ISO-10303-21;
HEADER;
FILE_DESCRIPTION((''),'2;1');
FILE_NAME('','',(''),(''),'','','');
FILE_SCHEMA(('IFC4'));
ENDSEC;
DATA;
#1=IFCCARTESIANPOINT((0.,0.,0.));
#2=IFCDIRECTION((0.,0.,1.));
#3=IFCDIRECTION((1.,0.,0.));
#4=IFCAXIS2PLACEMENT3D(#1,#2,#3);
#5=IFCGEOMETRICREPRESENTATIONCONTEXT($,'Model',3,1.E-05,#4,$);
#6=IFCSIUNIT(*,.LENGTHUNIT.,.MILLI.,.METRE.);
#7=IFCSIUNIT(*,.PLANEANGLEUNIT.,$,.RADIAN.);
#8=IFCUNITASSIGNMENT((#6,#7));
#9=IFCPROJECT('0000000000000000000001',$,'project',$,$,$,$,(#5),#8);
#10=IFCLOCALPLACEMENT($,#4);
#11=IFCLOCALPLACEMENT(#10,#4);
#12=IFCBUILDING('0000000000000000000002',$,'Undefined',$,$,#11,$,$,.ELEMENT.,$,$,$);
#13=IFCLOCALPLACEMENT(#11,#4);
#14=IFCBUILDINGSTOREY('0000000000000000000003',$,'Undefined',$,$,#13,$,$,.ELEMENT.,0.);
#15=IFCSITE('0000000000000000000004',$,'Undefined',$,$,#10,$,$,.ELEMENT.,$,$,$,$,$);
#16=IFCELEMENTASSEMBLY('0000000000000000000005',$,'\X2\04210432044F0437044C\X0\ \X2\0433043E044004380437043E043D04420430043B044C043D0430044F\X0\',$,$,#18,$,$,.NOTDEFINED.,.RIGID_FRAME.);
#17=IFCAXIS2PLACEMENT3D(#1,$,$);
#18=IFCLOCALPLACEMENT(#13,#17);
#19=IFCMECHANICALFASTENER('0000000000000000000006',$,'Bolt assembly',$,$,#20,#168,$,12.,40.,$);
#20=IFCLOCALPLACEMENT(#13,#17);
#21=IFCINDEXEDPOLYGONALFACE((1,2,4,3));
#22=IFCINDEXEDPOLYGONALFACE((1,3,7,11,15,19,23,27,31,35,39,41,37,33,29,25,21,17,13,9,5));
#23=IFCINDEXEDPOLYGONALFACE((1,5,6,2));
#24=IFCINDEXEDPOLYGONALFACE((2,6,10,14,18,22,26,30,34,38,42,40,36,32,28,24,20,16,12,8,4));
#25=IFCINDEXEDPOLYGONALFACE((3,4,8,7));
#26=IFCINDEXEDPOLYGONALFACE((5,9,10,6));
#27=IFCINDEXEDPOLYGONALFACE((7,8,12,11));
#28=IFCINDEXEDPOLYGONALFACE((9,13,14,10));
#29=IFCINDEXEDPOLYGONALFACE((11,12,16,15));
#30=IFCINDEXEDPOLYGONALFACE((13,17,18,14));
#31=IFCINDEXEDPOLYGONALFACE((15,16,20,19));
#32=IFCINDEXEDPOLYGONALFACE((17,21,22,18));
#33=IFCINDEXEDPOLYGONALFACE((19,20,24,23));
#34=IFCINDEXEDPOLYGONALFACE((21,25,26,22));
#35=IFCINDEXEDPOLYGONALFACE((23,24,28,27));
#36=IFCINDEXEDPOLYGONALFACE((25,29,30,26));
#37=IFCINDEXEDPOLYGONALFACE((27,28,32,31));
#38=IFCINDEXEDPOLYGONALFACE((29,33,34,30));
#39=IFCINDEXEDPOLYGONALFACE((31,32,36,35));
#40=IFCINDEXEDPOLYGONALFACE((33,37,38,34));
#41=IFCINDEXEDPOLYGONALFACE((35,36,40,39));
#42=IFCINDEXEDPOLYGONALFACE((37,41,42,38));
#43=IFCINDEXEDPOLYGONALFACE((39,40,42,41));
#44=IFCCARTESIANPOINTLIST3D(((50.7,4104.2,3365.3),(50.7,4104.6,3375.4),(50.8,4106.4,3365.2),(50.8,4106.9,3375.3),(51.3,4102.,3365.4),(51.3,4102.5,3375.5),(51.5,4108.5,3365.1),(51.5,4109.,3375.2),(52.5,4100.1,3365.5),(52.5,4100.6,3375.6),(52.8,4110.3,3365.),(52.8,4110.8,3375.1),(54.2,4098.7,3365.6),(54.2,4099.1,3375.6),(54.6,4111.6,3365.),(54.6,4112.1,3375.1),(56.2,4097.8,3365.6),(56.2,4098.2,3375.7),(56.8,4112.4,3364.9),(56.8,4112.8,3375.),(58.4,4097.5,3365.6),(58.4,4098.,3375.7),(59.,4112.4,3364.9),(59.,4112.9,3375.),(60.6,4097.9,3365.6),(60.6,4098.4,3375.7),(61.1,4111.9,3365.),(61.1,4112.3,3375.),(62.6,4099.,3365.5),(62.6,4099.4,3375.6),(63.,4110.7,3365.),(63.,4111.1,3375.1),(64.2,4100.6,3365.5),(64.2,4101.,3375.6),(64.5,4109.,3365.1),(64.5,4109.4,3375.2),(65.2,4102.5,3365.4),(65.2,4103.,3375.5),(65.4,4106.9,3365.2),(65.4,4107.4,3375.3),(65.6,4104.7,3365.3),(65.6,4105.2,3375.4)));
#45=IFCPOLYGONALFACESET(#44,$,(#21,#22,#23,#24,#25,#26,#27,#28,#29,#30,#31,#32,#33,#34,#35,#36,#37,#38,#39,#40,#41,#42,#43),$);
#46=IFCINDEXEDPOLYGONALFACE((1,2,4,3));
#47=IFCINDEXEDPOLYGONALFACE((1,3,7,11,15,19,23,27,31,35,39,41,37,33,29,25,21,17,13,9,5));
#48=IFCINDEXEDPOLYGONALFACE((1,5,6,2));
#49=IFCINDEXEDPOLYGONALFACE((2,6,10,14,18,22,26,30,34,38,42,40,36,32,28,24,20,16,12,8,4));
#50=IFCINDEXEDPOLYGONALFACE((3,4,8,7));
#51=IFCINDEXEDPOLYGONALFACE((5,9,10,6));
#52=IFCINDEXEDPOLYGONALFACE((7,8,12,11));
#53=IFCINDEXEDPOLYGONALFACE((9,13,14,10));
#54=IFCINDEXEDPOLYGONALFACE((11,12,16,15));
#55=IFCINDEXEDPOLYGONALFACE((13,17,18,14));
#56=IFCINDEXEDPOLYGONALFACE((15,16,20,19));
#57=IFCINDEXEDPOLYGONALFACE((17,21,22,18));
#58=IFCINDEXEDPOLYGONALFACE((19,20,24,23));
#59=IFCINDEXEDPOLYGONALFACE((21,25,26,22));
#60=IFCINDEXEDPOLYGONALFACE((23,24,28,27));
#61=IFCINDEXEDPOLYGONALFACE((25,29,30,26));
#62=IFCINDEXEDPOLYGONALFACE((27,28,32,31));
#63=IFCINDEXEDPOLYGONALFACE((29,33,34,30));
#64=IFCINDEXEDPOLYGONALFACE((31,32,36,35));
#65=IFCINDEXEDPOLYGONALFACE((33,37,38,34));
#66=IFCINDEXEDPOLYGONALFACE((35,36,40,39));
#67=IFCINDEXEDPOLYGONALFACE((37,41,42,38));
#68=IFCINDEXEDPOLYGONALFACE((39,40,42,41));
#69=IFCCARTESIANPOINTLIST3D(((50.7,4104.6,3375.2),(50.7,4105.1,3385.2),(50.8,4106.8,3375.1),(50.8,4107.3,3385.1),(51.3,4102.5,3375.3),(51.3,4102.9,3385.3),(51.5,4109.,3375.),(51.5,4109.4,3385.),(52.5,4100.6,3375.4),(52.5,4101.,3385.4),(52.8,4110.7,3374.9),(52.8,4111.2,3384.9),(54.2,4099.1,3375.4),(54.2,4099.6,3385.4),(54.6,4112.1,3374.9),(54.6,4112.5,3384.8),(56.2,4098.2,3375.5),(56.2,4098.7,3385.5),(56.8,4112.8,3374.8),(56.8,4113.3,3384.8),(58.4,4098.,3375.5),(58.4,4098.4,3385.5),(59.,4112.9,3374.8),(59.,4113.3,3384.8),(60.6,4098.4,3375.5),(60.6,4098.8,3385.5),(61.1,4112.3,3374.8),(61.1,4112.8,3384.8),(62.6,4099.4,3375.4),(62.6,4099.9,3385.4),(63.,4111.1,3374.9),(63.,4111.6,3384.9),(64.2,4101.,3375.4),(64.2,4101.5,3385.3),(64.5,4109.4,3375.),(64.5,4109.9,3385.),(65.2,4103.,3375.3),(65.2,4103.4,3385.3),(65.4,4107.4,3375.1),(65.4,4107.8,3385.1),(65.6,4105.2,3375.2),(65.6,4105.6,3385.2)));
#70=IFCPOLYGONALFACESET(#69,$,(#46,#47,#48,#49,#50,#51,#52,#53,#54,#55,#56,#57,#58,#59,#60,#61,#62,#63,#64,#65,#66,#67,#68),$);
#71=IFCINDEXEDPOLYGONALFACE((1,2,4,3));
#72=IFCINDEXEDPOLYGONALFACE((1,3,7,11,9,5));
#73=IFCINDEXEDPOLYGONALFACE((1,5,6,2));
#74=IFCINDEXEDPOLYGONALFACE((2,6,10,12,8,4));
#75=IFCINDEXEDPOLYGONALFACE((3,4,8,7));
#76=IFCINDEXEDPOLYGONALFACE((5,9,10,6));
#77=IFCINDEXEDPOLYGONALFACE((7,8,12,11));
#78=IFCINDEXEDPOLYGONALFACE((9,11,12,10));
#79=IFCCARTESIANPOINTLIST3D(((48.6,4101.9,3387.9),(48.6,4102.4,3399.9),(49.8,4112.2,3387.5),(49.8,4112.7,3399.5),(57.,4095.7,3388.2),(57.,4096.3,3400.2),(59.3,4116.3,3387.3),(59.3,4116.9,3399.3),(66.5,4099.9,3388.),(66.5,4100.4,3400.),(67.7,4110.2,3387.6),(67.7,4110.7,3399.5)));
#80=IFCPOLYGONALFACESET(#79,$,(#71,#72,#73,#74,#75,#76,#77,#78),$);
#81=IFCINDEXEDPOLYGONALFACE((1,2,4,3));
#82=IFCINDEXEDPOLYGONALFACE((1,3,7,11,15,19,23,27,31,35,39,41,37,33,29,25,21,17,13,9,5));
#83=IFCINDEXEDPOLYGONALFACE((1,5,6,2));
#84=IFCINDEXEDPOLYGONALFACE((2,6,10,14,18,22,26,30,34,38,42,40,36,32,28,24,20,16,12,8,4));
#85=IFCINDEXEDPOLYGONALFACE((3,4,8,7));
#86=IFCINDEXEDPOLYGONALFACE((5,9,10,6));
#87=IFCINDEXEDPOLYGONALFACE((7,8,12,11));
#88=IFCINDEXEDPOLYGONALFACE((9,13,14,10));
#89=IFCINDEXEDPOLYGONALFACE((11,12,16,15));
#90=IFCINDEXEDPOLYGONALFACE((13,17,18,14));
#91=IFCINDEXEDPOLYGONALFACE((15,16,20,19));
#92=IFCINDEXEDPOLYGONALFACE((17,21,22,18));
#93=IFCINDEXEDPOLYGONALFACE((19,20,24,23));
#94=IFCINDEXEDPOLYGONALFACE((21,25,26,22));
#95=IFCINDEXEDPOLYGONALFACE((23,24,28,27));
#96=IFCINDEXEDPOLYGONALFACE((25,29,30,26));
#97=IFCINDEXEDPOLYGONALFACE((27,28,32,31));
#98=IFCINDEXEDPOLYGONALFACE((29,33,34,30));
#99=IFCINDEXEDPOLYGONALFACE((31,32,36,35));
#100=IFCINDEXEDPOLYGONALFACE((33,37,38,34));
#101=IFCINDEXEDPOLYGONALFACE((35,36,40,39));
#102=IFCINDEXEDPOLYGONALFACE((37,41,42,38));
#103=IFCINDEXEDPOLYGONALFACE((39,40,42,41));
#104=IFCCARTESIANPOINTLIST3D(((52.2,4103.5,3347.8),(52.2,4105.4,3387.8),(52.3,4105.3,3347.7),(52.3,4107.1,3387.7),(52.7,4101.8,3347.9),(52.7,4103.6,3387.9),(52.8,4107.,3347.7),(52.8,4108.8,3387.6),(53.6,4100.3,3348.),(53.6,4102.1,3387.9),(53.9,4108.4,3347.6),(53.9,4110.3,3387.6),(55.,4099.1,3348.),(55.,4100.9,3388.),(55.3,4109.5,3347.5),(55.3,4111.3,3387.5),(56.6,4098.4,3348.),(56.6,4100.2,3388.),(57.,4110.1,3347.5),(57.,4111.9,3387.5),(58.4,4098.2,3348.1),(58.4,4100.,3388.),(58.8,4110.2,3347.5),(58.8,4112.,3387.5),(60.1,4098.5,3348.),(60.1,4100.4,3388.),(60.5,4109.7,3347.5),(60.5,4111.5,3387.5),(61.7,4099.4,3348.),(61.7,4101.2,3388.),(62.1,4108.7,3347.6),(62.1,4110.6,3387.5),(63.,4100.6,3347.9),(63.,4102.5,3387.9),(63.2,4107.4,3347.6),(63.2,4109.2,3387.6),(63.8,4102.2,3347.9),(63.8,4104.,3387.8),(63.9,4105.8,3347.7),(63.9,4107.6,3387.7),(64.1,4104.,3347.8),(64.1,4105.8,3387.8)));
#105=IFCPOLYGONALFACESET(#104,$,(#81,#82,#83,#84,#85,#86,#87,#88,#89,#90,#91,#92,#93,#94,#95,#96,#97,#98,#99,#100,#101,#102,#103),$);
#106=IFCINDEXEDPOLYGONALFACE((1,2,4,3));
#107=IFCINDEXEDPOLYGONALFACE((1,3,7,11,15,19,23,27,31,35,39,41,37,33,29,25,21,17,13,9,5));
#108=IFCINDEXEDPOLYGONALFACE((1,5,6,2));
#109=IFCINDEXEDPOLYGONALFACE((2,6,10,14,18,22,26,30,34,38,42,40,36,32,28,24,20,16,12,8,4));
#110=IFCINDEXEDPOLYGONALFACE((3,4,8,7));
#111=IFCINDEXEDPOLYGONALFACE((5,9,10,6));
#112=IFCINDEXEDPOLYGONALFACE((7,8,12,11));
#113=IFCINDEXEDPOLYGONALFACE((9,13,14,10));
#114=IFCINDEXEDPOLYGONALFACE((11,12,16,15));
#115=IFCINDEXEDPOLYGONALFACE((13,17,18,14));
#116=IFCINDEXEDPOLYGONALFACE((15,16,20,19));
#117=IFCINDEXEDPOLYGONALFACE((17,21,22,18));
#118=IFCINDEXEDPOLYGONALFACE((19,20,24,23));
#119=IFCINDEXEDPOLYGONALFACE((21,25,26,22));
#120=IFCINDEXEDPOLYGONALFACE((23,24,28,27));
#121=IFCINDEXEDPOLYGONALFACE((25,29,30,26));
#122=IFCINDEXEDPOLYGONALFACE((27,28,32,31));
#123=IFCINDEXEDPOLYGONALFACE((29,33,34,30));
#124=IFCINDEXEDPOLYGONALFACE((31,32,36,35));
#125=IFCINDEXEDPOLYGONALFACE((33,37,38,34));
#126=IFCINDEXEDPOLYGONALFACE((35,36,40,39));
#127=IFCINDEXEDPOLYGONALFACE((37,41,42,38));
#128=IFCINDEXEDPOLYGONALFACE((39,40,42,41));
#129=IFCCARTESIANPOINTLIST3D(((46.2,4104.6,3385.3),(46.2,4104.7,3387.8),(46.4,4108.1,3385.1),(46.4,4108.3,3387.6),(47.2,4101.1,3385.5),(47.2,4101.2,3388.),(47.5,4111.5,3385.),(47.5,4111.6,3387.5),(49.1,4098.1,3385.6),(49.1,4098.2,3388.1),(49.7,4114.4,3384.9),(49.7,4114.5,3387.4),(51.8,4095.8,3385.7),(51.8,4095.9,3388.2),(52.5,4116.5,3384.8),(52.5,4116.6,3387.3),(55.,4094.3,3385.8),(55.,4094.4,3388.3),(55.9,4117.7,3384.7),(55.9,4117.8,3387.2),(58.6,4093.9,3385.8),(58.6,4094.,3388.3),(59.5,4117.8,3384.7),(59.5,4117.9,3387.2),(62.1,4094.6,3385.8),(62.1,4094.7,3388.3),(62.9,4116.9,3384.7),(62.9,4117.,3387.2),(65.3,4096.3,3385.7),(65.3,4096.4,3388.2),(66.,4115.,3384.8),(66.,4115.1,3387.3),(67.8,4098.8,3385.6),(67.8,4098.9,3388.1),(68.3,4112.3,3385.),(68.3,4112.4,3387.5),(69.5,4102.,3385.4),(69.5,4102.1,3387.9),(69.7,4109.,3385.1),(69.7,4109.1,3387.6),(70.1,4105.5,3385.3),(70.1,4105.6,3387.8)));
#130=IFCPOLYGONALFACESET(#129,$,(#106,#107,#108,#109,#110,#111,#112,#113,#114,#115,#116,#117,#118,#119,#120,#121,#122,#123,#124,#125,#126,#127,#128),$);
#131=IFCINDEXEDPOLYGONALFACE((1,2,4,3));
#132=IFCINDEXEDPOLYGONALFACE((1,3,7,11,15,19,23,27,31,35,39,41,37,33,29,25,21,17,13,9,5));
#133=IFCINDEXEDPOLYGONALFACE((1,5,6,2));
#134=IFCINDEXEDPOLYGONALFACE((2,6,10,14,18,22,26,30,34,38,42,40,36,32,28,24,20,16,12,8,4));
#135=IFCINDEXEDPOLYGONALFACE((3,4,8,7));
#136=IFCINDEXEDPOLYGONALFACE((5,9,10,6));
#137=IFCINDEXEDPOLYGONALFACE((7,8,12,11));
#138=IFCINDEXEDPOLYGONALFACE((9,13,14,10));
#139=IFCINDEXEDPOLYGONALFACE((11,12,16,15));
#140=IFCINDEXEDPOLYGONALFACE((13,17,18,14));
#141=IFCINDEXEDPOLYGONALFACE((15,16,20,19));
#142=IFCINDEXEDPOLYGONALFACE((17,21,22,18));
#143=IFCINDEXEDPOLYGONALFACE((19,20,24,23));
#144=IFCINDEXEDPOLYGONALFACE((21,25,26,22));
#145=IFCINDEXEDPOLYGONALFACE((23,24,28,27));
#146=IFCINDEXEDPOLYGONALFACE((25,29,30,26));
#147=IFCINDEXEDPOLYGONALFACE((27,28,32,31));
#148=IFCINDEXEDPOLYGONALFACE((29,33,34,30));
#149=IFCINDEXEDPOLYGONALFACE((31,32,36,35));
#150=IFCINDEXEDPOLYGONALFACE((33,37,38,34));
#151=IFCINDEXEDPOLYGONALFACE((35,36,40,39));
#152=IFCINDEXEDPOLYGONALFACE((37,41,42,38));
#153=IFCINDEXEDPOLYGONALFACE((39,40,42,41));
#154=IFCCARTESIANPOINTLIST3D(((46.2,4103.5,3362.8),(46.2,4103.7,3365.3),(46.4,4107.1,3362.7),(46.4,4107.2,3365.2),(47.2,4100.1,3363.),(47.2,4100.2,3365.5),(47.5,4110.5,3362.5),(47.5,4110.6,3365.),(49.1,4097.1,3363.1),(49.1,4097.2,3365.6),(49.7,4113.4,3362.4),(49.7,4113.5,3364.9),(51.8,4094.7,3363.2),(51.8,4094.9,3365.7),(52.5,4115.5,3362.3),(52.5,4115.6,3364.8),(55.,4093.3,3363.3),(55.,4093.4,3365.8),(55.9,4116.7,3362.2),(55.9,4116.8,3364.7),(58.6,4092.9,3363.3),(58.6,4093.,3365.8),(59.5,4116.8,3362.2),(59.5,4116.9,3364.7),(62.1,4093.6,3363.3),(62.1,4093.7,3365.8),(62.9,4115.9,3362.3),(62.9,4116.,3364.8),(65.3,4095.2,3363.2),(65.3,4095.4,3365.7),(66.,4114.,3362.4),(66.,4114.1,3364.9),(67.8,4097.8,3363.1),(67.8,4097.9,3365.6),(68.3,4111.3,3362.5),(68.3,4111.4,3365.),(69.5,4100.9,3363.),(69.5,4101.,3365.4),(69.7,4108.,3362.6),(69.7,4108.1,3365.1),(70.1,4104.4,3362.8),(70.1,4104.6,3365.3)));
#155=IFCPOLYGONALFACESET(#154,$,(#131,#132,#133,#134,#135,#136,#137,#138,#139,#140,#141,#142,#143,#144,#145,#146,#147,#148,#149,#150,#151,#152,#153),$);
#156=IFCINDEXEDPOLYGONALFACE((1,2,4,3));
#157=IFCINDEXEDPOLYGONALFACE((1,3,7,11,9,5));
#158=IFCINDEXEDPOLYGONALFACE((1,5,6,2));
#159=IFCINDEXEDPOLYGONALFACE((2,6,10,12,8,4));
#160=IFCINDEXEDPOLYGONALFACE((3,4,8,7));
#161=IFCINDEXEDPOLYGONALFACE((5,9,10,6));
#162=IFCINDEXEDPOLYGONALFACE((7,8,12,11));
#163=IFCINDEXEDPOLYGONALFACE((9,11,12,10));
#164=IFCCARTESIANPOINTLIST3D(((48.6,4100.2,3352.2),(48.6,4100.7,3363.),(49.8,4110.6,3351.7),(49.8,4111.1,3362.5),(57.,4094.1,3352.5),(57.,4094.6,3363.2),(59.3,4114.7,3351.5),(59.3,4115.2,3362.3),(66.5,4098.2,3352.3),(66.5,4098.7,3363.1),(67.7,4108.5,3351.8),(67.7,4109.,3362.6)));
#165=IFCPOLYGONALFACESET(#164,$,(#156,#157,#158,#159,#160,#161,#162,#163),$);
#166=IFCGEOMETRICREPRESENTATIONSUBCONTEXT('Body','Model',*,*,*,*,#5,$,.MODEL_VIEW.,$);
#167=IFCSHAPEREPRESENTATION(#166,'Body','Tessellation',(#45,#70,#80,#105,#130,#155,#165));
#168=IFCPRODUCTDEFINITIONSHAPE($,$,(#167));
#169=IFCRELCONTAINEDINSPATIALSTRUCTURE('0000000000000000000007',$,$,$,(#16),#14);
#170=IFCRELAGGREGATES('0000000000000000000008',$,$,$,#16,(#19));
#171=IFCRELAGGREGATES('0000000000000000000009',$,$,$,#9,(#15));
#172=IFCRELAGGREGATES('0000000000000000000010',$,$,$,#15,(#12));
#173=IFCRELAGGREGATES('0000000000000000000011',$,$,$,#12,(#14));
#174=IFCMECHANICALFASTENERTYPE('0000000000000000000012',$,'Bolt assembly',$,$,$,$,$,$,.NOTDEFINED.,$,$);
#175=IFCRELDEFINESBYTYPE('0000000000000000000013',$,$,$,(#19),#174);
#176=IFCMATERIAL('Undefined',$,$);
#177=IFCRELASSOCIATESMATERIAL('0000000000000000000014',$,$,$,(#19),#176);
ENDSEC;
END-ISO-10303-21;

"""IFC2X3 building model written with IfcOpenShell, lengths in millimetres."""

from ifc_helpers import new_model, si_unit, frame, origin_with_axes, origin_2d_with_axis, place, context, subcontext, project, spatial, polyline, circle, outline, extrude, source, transform, mapped, material, type_object, element, aggregate, save


model = new_model("IFC2X3")

# Units and contexts
model_context = context("Model", 3, precision=1e-05, world=origin_with_axes())
body_context = subcontext(model_context, "Body", "Model", "MODEL_VIEW")
ifc_project = project(units=[si_unit("LENGTHUNIT", "METRE", prefix="MILLI"), si_unit("PLANEANGLEUNIT", "RADIAN")], contexts=[model_context])

# Site, building, storey
site_placement = place(None, origin_with_axes())
site = spatial("IfcSite", under=ifc_project, at=site_placement, Name="Undefined", CompositionType="ELEMENT")
building_placement = place(site_placement, origin_with_axes())
building = spatial("IfcBuilding", under=site, at=building_placement, Name="Undefined", CompositionType="ELEMENT")
storey_placement = place(building_placement, origin_with_axes())
storey = spatial("IfcBuildingStorey", under=building, at=storey_placement, Name="Undefined", CompositionType="ELEMENT", Elevation=0.0)

# Element assembly
assembly_1_placement = place(storey_placement, origin_with_axes())
assembly_1 = element("IfcElementAssembly", 1, at=assembly_1_placement, inside=storey, Name="Связь горизонтальная", AssemblyPlace="NOTDEFINED", PredefinedType="RIGID_FRAME")

# Mechanical fastener
ifc_material_1 = material(Name="Undefined")
mechanical_fastener_type = type_object("IfcMechanicalFastenerType", Name="Bolt assembly")
shared_shape_1 = source(origin_with_axes(), body_context, "Body", "SweptSolid", [
    extrude(circle(Radius=7.5, at=origin_2d_with_axis()), frame((0.0, -0.1, 0.0), z_axis=(0.0, 1.0, 0.0), x_axis=(1.0, 0.0, 0.0)), (0.0, 0.0, 1.0), 10.1),
    extrude(circle(Radius=7.5, at=origin_2d_with_axis()), frame((0.0, -9.9, 0.0), z_axis=(0.0, 1.0, 0.0), x_axis=(1.0, 0.0, 0.0)), (0.0, 0.0, 1.0), 10.0),
    extrude(outline(polyline([(10.4, 0.0), (5.2, 9.0), (-5.2, 9.0), (-10.4, 0.0), (-5.2, -9.0), (5.2, -9.0), (10.4, 0.0)])), frame((0.0, -24.5, 0.0), z_axis=(0.0, 1.0, 0.0), x_axis=(1.0, 0.0, 0.0)), (0.0, 0.0, 1.0), 12.0),
    extrude(circle(Radius=6.0, at=origin_2d_with_axis()), frame((0.0, -12.5, 0.0), z_axis=(0.0, 1.0, 0.0), x_axis=(1.0, 0.0, 0.0)), (0.0, 0.0, 1.0), 40.0),
    extrude(circle(Radius=12.0, at=origin_2d_with_axis()), frame((0.0, -12.5, 0.0), z_axis=(0.0, 1.0, 0.0), x_axis=(1.0, 0.0, 0.0)), (0.0, 0.0, 1.0), 2.5),
    extrude(circle(Radius=12.0, at=origin_2d_with_axis()), frame((0.0, 10.0, 0.0), z_axis=(0.0, 1.0, 0.0), x_axis=(1.0, 0.0, 0.0)), (0.0, 0.0, 1.0), 2.5),
    extrude(outline(polyline([(10.4, 0.0), (5.2, 9.0), (-5.2, 9.0), (-10.4, 0.0), (-5.2, -9.0), (5.2, -9.0), (10.4, 0.0)])), frame((0.0, 12.5, 0.0), z_axis=(0.0, 1.0, 0.0), x_axis=(1.0, 0.0, 0.0)), (0.0, 0.0, 1.0), 10.8),
])
mechanical_fastener_1_placement = place(assembly_1_placement, frame((58.1, 4105.5, 3375.3), z_axis=(0.593795, 0.803786, -0.036536), x_axis=(0.804616, -0.593183, 0.026963)))
mechanical_fastener_1 = element("IfcMechanicalFastener", 2, at=mechanical_fastener_1_placement, type_object=mechanical_fastener_type, material=ifc_material_1, Name="Bolt assembly", NominalDiameter=12.0, NominalLength=40.0, context=body_context, shape_type="MappedRepresentation", body=[
    mapped(shared_shape_1, transform((0.0, 0.0, 0.0))),
])
aggregate(assembly_1, [mechanical_fastener_1])

save(model, "model.ifc")
